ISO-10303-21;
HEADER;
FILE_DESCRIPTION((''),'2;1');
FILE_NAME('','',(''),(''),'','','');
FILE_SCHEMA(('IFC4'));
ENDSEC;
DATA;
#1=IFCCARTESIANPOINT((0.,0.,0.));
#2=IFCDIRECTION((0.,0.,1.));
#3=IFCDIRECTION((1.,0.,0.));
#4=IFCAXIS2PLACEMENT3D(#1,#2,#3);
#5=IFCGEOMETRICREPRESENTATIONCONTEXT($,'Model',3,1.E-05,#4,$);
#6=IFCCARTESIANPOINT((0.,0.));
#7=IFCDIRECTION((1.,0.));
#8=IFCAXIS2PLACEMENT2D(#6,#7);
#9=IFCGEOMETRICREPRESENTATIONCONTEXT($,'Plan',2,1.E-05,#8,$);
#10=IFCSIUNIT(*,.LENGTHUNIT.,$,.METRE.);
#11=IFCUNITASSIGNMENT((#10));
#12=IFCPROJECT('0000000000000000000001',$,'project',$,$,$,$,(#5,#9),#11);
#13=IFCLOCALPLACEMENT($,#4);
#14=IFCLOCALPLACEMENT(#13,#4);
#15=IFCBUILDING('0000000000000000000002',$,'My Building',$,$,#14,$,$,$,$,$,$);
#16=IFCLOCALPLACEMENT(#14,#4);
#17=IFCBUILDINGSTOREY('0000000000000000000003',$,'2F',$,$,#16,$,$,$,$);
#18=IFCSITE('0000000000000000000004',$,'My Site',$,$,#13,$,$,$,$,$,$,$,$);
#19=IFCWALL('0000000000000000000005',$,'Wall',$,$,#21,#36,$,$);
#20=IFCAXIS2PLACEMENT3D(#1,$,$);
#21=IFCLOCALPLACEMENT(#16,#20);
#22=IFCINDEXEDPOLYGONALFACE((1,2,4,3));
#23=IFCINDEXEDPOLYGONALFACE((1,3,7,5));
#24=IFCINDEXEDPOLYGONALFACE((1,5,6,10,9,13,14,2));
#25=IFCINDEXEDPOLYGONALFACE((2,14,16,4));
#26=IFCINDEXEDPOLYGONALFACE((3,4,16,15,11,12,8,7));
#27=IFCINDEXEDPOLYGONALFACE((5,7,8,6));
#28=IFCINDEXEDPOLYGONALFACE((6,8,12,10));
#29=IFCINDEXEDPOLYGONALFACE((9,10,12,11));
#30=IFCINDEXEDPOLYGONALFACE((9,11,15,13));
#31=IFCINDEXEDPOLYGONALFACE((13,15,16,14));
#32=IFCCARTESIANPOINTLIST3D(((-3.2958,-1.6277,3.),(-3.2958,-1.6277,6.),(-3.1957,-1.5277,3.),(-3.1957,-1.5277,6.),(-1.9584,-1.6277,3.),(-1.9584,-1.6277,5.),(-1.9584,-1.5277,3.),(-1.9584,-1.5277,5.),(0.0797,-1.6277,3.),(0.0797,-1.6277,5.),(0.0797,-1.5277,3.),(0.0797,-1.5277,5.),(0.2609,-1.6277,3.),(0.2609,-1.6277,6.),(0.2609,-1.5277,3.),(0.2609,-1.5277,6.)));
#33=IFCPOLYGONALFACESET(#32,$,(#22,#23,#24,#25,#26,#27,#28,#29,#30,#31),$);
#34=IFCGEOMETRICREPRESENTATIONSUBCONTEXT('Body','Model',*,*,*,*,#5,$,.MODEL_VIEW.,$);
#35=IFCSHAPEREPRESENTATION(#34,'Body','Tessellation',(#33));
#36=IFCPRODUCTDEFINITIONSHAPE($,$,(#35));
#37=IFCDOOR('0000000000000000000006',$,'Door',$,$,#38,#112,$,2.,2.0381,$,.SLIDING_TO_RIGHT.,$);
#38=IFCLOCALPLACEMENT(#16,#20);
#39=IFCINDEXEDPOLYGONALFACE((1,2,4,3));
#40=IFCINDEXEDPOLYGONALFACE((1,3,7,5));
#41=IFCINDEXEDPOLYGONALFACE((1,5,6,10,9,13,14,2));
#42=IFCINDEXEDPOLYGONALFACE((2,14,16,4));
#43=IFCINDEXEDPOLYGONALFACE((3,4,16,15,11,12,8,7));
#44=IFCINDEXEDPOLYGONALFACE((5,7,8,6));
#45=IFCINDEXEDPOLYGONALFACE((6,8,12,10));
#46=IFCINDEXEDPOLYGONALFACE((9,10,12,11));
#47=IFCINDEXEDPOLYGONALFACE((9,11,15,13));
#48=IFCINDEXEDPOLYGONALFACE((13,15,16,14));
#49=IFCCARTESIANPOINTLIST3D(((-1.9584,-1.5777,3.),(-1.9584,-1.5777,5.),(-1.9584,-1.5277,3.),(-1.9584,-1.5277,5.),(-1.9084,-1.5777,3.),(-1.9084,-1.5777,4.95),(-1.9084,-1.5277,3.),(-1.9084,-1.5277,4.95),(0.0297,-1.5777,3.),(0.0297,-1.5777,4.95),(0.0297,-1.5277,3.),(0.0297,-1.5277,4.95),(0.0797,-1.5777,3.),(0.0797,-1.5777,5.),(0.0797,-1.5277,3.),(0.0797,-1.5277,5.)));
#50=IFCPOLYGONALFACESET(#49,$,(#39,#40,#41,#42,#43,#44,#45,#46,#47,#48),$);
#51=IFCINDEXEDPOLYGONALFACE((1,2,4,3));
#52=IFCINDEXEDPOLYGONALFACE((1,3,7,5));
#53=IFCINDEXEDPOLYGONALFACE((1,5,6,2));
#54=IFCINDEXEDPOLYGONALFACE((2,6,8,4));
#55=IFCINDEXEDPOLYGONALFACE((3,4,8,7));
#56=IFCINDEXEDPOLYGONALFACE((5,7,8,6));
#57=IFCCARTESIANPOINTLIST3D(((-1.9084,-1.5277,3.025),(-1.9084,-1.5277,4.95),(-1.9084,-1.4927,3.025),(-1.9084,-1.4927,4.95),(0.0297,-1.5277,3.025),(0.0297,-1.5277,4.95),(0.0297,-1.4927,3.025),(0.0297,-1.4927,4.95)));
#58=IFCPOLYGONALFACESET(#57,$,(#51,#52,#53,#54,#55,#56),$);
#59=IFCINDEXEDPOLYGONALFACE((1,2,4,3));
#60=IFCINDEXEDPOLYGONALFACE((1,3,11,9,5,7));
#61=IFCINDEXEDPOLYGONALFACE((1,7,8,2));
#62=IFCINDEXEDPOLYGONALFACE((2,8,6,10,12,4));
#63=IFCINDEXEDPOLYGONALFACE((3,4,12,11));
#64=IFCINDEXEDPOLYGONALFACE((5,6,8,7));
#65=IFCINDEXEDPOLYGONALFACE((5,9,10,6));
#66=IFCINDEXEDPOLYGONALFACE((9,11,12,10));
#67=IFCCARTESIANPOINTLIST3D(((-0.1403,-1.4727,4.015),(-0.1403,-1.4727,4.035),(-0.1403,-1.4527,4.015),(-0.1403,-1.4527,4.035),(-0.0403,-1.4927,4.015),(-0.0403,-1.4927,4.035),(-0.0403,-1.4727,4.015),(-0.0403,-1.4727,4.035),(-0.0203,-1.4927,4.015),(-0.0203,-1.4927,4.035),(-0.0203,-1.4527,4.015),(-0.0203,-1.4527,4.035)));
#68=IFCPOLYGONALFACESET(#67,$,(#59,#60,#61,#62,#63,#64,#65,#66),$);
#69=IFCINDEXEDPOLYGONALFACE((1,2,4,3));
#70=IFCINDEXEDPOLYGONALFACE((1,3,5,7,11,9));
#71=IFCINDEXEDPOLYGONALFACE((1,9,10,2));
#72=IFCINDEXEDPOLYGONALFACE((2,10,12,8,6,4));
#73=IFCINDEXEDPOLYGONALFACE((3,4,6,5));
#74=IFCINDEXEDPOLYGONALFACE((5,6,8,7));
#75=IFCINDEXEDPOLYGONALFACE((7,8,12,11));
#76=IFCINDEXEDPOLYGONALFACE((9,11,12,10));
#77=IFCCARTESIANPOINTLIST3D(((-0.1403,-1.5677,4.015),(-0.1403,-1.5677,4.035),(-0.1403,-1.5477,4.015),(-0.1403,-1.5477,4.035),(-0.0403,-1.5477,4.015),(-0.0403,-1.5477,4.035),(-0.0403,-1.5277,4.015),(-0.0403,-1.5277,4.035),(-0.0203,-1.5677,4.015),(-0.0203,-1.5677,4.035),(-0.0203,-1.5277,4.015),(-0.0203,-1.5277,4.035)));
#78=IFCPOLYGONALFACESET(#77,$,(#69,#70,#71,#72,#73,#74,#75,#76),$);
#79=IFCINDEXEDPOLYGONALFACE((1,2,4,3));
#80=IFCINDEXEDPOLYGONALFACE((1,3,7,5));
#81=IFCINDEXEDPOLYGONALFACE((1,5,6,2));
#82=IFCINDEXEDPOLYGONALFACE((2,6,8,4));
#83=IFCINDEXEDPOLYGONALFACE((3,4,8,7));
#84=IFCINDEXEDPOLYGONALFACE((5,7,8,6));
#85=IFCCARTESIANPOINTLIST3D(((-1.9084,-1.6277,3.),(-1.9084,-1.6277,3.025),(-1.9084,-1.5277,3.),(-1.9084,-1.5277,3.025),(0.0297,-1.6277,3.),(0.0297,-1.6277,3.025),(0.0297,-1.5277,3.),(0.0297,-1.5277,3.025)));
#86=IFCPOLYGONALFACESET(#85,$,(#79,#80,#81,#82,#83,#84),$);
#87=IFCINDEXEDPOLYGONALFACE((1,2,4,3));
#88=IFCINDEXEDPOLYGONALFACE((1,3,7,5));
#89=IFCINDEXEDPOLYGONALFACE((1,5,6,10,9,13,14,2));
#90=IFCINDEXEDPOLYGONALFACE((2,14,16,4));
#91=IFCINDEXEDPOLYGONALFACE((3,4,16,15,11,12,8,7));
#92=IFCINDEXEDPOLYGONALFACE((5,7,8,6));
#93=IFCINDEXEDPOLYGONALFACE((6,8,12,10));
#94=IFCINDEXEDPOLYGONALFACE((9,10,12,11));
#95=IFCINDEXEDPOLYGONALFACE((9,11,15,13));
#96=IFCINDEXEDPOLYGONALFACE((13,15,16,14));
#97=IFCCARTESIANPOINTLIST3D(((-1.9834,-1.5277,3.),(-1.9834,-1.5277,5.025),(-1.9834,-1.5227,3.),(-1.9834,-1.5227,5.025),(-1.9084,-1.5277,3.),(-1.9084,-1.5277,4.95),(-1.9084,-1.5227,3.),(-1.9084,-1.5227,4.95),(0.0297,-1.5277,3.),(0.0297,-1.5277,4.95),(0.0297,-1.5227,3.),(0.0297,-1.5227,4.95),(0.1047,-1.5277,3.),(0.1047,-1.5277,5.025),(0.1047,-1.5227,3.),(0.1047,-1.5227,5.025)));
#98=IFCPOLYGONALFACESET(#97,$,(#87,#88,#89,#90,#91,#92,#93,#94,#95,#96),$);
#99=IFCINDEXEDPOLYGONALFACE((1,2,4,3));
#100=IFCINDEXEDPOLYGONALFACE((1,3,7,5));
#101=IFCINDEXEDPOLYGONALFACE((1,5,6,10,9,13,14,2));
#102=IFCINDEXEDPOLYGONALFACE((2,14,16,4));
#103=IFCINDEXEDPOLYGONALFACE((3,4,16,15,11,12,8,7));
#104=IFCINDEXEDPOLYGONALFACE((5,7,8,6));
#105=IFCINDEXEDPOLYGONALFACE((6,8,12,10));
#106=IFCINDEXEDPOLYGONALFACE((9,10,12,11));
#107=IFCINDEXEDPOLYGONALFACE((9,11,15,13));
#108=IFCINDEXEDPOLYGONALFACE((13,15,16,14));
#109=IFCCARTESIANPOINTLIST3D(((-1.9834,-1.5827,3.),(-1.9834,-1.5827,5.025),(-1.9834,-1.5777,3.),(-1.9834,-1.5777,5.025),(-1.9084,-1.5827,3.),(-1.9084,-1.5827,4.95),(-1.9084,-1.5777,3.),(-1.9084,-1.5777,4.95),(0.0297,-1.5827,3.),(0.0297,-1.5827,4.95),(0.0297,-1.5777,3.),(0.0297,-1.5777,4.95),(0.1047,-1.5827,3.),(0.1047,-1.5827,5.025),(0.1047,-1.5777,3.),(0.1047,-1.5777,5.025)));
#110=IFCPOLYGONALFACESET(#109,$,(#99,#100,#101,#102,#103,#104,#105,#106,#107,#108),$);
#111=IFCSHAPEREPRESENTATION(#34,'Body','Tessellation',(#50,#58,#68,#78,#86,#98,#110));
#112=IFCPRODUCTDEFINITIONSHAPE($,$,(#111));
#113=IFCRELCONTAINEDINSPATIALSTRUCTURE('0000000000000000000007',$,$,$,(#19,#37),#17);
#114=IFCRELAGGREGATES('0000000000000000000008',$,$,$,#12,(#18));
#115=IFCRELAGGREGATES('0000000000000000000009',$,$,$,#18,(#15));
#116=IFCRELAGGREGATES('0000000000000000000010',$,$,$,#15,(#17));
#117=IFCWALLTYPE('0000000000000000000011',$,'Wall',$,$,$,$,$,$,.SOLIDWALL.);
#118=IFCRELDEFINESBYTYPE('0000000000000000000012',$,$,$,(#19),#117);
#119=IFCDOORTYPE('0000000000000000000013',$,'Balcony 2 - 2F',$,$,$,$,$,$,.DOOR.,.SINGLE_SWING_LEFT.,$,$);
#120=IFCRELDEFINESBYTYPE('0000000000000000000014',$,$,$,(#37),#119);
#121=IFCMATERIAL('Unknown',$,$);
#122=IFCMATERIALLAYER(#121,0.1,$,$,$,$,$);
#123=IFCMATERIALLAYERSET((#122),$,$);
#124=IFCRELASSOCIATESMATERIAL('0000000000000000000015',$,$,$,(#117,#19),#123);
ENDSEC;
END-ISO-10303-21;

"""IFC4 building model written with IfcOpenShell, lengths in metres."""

from ifc_helpers import new_model, entity, si_unit, frame, origin_with_axes, origin_2d_with_axis, place, context, subcontext, project, spatial, line, indexed_curve, outline, extrude, shape, source, transform, mapped, material, layer, layer_set, layer_usage, type_object, type_shapes, element, fill, save


model = new_model("IFC4")

# Units and contexts
model_context = context("Model", 3, precision=1e-05, world=origin_with_axes())
plan_context = context("Plan", 2, precision=1e-05, world=origin_2d_with_axis())
body_context_1 = subcontext(model_context, "Body", "Model", "MODEL_VIEW")
body_context_2 = subcontext(plan_context, "Body", "Plan", "PLAN_VIEW")
ifc_project = project(units=[si_unit("LENGTHUNIT", "METRE")], contexts=[model_context, plan_context])

# Site, building, storey
site_placement = place(None, origin_with_axes())
site = spatial("IfcSite", under=ifc_project, at=site_placement, Name="My Site")
building_placement = place(site_placement, origin_with_axes())
building = spatial("IfcBuilding", under=site, at=building_placement, Name="My Building")
storey_placement = place(building_placement, origin_with_axes())
storey = spatial("IfcBuildingStorey", under=building, at=storey_placement, Name="2F")

# Shared definitions
ifc_material = material(Name="Unknown")
ifc_layer = layer(ifc_material, 0.1)
ifc_layer_set = layer_set([ifc_layer])
wall_type = type_object("IfcWallType", Name="Wall", PredefinedType="SOLIDWALL", material=ifc_layer_set)

# Wall, opening, door
ifc_layer_usage_1 = layer_usage(ifc_layer_set, "AXIS2", "POSITIVE", 0.0)
wall_1_placement = place(storey_placement, frame((-3.2958, -1.6277, 3.0), z_axis=(0.0, 0.0, 1.0), x_axis=(1.0, 0.0, 0.0)))
wall_1 = element("IfcWall", 1, at=wall_1_placement, inside=storey, type_object=wall_type, material=ifc_layer_usage_1, Name="Wall", context=body_context_1, shape_type="SweptSolid", body=[
    extrude(outline(indexed_curve([(0.0, 0.0), (0.1002, 0.1), (3.5568, 0.1), (3.5568, 0.0)], segments=[line(1, 2, 3, 4, 1)])), origin_with_axes(), (0.0, 0.0, 1.0), 3.0),
])
shared_shape_1 = source(origin_with_axes(), body_context_1, "Body", "SweptSolid", [
    extrude(outline(indexed_curve([(0.0, 0.0), (2.0381, 0.0), (2.0381, 2.0), (0.0, 2.0)], segments=[line(1, 2, 3, 4, 1)])), frame((0.0, -0.6, 0.0), z_axis=(0.0, -1.0, 0.0), x_axis=(1.0, 0.0, 0.0)), (0.0, 0.0, -1.0), 1.2),
])
opening_1_placement = place(wall_1_placement, frame((3.3755, 0.1, 0.0), z_axis=(0.0, 0.0, 1.0), x_axis=(-1.0, 0.0, 0.0)))
opening_1 = element("IfcOpeningElement", 2, at=opening_1_placement, cuts=wall_1, PredefinedType="OPENING", context=body_context_1, shape_type="MappedRepresentation", body=[
    mapped(shared_shape_1, transform((0.0, 0.0, 0.0), x_axis=(1.0, 0.0, 0.0), y_axis=(0.0, 1.0, 0.0), z_axis=(0.0, 0.0, 1.0), scale=1.0)),
])
door_type_1 = type_object("IfcDoorType", Name="Balcony 2 - 2F", OperationType="SINGLE_SWING_LEFT", PredefinedType="DOOR")
shared_shape_2 = source(origin_with_axes(), body_context_1, "Body", "SweptSolid", [
    extrude(outline(indexed_curve([(0.0, 0.0), (0.0, 2.0), (2.0381, 2.0), (2.0381, 0.0), (1.9881, 0.0), (1.9881, 1.95), (0.05, 1.95), (0.05, 0.0)], segments=[line(1, 2, 3, 4, 5, 6, 7, 8, 1)])), frame((0.0, 0.0, 0.0), z_axis=(0.0, -1.0, 0.0), x_axis=(1.0, 0.0, 0.0)), (0.0, 0.0, -1.0), 0.05),
    extrude(outline(indexed_curve([(0.0, 0.0), (1.9381, 0.0), (1.9381, 0.035), (0.0, 0.035)], segments=[line(1, 2, 3, 4, 1)])), frame((0.05, -0.035, 0.025), z_axis=(0.0, 0.0, 1.0), x_axis=(1.0, 0.0, 0.0)), (0.0, 0.0, 1.0), 1.925),
    extrude(outline(indexed_curve([(0.0, 0.0), (0.0, -0.04), (0.12, -0.04), (0.12, -0.02), (0.02, -0.02), (0.02, 0.0)], segments=[line(1, 2, 3, 4, 5, 6, 1)])), frame((0.1, -0.035, 1.015), z_axis=(0.0, 0.0, 1.0), x_axis=(1.0, 0.0, 0.0)), (0.0, 0.0, 1.0), 0.02),
    extrude(outline(indexed_curve([(0.0, 0.0), (0.0, 0.04), (0.12, 0.04), (0.12, 0.02), (0.02, 0.02), (0.02, 0.0)], segments=[line(1, 2, 3, 4, 5, 6, 1)])), frame((0.1, 0.0, 1.015), z_axis=(0.0, 0.0, 1.0), x_axis=(1.0, 0.0, 0.0)), (0.0, 0.0, 1.0), 0.02),
    extrude(outline(indexed_curve([(0.0, 0.0), (1.9381, 0.0), (1.9381, 0.1), (0.0, 0.1)], segments=[line(1, 2, 3, 4, 1)])), frame((0.05, 0.0, 0.0), z_axis=(0.0, 0.0, 1.0), x_axis=(1.0, 0.0, 0.0)), (0.0, 0.0, 1.0), 0.025),
    extrude(outline(indexed_curve([(0.0, 0.0), (0.0, 2.025), (2.0881, 2.025), (2.0881, 0.0), (2.0131, 0.0), (2.0131, 1.95), (0.075, 1.95), (0.075, 0.0)], segments=[line(1, 2, 3, 4, 5, 6, 7, 8, 1)])), frame((-0.025, -0.005, 0.0), z_axis=(0.0, -1.0, 0.0), x_axis=(1.0, 0.0, 0.0)), (0.0, 0.0, -1.0), 0.005),
    extrude(outline(indexed_curve([(0.0, 0.0), (0.0, 2.025), (2.0881, 2.025), (2.0881, 0.0), (2.0131, 0.0), (2.0131, 1.95), (0.075, 1.95), (0.075, 0.0)], segments=[line(1, 2, 3, 4, 5, 6, 7, 8, 1)])), frame((-0.025, 0.05, 0.0), z_axis=(0.0, -1.0, 0.0), x_axis=(1.0, 0.0, 0.0)), (0.0, 0.0, -1.0), 0.005),
])
shared_shape_3 = source(origin_with_axes(), body_context_2, "Body", "Curve2D", [
    entity("IfcIndexedPolyCurve", entity("IfcCartesianPointList2D", [[0.0, 0.0], [0.05, 0.0], [0.05, 0.05], [0.0, 0.05]]), [entity("IfcLineIndex", [1, 2, 3, 4, 1])]),
    entity("IfcIndexedPolyCurve", entity("IfcCartesianPointList2D", [[2.0381, 0.0], [1.9881, 0.0], [1.9881, 0.05], [2.0381, 0.05]]), [entity("IfcLineIndex", [1, 2, 3, 4, 1])]),
    entity("IfcIndexedPolyCurve", entity("IfcCartesianPointList2D", [[2.9571, -0.035], [1.019, -0.035], [1.019, 0.0], [2.9571, 0.0]]), [entity("IfcLineIndex", [1, 2, 3, 4, 1])]),
])
type_shapes(door_type_1, [shared_shape_2, shared_shape_3])
door_1_placement = place(opening_1_placement, origin_with_axes())
door_1 = element("IfcDoor", 3, at=door_1_placement, inside=storey, type_object=door_type_1, Name="Door", OperationType="SLIDING_TO_RIGHT", OverallHeight=2.0, OverallWidth=2.0381, shapes=[
    shape(body_context_1, "Body", "MappedRepresentation", [mapped(shared_shape_2, transform((0.0, 0.0, 0.0), x_axis=(1.0, 0.0, 0.0), y_axis=(0.0, 1.0, 0.0), z_axis=(0.0, 0.0, 1.0), scale=1.0))]),
    shape(body_context_2, "Body", "MappedRepresentation", [mapped(shared_shape_3, transform((0.0, 0.0, 0.0), x_axis=(1.0, 0.0, 0.0), y_axis=(0.0, 1.0, 0.0), z_axis=(0.0, 0.0, 1.0), scale=1.0))]),
])
fill(opening_1, door_1)

save(model, "model.ifc")
